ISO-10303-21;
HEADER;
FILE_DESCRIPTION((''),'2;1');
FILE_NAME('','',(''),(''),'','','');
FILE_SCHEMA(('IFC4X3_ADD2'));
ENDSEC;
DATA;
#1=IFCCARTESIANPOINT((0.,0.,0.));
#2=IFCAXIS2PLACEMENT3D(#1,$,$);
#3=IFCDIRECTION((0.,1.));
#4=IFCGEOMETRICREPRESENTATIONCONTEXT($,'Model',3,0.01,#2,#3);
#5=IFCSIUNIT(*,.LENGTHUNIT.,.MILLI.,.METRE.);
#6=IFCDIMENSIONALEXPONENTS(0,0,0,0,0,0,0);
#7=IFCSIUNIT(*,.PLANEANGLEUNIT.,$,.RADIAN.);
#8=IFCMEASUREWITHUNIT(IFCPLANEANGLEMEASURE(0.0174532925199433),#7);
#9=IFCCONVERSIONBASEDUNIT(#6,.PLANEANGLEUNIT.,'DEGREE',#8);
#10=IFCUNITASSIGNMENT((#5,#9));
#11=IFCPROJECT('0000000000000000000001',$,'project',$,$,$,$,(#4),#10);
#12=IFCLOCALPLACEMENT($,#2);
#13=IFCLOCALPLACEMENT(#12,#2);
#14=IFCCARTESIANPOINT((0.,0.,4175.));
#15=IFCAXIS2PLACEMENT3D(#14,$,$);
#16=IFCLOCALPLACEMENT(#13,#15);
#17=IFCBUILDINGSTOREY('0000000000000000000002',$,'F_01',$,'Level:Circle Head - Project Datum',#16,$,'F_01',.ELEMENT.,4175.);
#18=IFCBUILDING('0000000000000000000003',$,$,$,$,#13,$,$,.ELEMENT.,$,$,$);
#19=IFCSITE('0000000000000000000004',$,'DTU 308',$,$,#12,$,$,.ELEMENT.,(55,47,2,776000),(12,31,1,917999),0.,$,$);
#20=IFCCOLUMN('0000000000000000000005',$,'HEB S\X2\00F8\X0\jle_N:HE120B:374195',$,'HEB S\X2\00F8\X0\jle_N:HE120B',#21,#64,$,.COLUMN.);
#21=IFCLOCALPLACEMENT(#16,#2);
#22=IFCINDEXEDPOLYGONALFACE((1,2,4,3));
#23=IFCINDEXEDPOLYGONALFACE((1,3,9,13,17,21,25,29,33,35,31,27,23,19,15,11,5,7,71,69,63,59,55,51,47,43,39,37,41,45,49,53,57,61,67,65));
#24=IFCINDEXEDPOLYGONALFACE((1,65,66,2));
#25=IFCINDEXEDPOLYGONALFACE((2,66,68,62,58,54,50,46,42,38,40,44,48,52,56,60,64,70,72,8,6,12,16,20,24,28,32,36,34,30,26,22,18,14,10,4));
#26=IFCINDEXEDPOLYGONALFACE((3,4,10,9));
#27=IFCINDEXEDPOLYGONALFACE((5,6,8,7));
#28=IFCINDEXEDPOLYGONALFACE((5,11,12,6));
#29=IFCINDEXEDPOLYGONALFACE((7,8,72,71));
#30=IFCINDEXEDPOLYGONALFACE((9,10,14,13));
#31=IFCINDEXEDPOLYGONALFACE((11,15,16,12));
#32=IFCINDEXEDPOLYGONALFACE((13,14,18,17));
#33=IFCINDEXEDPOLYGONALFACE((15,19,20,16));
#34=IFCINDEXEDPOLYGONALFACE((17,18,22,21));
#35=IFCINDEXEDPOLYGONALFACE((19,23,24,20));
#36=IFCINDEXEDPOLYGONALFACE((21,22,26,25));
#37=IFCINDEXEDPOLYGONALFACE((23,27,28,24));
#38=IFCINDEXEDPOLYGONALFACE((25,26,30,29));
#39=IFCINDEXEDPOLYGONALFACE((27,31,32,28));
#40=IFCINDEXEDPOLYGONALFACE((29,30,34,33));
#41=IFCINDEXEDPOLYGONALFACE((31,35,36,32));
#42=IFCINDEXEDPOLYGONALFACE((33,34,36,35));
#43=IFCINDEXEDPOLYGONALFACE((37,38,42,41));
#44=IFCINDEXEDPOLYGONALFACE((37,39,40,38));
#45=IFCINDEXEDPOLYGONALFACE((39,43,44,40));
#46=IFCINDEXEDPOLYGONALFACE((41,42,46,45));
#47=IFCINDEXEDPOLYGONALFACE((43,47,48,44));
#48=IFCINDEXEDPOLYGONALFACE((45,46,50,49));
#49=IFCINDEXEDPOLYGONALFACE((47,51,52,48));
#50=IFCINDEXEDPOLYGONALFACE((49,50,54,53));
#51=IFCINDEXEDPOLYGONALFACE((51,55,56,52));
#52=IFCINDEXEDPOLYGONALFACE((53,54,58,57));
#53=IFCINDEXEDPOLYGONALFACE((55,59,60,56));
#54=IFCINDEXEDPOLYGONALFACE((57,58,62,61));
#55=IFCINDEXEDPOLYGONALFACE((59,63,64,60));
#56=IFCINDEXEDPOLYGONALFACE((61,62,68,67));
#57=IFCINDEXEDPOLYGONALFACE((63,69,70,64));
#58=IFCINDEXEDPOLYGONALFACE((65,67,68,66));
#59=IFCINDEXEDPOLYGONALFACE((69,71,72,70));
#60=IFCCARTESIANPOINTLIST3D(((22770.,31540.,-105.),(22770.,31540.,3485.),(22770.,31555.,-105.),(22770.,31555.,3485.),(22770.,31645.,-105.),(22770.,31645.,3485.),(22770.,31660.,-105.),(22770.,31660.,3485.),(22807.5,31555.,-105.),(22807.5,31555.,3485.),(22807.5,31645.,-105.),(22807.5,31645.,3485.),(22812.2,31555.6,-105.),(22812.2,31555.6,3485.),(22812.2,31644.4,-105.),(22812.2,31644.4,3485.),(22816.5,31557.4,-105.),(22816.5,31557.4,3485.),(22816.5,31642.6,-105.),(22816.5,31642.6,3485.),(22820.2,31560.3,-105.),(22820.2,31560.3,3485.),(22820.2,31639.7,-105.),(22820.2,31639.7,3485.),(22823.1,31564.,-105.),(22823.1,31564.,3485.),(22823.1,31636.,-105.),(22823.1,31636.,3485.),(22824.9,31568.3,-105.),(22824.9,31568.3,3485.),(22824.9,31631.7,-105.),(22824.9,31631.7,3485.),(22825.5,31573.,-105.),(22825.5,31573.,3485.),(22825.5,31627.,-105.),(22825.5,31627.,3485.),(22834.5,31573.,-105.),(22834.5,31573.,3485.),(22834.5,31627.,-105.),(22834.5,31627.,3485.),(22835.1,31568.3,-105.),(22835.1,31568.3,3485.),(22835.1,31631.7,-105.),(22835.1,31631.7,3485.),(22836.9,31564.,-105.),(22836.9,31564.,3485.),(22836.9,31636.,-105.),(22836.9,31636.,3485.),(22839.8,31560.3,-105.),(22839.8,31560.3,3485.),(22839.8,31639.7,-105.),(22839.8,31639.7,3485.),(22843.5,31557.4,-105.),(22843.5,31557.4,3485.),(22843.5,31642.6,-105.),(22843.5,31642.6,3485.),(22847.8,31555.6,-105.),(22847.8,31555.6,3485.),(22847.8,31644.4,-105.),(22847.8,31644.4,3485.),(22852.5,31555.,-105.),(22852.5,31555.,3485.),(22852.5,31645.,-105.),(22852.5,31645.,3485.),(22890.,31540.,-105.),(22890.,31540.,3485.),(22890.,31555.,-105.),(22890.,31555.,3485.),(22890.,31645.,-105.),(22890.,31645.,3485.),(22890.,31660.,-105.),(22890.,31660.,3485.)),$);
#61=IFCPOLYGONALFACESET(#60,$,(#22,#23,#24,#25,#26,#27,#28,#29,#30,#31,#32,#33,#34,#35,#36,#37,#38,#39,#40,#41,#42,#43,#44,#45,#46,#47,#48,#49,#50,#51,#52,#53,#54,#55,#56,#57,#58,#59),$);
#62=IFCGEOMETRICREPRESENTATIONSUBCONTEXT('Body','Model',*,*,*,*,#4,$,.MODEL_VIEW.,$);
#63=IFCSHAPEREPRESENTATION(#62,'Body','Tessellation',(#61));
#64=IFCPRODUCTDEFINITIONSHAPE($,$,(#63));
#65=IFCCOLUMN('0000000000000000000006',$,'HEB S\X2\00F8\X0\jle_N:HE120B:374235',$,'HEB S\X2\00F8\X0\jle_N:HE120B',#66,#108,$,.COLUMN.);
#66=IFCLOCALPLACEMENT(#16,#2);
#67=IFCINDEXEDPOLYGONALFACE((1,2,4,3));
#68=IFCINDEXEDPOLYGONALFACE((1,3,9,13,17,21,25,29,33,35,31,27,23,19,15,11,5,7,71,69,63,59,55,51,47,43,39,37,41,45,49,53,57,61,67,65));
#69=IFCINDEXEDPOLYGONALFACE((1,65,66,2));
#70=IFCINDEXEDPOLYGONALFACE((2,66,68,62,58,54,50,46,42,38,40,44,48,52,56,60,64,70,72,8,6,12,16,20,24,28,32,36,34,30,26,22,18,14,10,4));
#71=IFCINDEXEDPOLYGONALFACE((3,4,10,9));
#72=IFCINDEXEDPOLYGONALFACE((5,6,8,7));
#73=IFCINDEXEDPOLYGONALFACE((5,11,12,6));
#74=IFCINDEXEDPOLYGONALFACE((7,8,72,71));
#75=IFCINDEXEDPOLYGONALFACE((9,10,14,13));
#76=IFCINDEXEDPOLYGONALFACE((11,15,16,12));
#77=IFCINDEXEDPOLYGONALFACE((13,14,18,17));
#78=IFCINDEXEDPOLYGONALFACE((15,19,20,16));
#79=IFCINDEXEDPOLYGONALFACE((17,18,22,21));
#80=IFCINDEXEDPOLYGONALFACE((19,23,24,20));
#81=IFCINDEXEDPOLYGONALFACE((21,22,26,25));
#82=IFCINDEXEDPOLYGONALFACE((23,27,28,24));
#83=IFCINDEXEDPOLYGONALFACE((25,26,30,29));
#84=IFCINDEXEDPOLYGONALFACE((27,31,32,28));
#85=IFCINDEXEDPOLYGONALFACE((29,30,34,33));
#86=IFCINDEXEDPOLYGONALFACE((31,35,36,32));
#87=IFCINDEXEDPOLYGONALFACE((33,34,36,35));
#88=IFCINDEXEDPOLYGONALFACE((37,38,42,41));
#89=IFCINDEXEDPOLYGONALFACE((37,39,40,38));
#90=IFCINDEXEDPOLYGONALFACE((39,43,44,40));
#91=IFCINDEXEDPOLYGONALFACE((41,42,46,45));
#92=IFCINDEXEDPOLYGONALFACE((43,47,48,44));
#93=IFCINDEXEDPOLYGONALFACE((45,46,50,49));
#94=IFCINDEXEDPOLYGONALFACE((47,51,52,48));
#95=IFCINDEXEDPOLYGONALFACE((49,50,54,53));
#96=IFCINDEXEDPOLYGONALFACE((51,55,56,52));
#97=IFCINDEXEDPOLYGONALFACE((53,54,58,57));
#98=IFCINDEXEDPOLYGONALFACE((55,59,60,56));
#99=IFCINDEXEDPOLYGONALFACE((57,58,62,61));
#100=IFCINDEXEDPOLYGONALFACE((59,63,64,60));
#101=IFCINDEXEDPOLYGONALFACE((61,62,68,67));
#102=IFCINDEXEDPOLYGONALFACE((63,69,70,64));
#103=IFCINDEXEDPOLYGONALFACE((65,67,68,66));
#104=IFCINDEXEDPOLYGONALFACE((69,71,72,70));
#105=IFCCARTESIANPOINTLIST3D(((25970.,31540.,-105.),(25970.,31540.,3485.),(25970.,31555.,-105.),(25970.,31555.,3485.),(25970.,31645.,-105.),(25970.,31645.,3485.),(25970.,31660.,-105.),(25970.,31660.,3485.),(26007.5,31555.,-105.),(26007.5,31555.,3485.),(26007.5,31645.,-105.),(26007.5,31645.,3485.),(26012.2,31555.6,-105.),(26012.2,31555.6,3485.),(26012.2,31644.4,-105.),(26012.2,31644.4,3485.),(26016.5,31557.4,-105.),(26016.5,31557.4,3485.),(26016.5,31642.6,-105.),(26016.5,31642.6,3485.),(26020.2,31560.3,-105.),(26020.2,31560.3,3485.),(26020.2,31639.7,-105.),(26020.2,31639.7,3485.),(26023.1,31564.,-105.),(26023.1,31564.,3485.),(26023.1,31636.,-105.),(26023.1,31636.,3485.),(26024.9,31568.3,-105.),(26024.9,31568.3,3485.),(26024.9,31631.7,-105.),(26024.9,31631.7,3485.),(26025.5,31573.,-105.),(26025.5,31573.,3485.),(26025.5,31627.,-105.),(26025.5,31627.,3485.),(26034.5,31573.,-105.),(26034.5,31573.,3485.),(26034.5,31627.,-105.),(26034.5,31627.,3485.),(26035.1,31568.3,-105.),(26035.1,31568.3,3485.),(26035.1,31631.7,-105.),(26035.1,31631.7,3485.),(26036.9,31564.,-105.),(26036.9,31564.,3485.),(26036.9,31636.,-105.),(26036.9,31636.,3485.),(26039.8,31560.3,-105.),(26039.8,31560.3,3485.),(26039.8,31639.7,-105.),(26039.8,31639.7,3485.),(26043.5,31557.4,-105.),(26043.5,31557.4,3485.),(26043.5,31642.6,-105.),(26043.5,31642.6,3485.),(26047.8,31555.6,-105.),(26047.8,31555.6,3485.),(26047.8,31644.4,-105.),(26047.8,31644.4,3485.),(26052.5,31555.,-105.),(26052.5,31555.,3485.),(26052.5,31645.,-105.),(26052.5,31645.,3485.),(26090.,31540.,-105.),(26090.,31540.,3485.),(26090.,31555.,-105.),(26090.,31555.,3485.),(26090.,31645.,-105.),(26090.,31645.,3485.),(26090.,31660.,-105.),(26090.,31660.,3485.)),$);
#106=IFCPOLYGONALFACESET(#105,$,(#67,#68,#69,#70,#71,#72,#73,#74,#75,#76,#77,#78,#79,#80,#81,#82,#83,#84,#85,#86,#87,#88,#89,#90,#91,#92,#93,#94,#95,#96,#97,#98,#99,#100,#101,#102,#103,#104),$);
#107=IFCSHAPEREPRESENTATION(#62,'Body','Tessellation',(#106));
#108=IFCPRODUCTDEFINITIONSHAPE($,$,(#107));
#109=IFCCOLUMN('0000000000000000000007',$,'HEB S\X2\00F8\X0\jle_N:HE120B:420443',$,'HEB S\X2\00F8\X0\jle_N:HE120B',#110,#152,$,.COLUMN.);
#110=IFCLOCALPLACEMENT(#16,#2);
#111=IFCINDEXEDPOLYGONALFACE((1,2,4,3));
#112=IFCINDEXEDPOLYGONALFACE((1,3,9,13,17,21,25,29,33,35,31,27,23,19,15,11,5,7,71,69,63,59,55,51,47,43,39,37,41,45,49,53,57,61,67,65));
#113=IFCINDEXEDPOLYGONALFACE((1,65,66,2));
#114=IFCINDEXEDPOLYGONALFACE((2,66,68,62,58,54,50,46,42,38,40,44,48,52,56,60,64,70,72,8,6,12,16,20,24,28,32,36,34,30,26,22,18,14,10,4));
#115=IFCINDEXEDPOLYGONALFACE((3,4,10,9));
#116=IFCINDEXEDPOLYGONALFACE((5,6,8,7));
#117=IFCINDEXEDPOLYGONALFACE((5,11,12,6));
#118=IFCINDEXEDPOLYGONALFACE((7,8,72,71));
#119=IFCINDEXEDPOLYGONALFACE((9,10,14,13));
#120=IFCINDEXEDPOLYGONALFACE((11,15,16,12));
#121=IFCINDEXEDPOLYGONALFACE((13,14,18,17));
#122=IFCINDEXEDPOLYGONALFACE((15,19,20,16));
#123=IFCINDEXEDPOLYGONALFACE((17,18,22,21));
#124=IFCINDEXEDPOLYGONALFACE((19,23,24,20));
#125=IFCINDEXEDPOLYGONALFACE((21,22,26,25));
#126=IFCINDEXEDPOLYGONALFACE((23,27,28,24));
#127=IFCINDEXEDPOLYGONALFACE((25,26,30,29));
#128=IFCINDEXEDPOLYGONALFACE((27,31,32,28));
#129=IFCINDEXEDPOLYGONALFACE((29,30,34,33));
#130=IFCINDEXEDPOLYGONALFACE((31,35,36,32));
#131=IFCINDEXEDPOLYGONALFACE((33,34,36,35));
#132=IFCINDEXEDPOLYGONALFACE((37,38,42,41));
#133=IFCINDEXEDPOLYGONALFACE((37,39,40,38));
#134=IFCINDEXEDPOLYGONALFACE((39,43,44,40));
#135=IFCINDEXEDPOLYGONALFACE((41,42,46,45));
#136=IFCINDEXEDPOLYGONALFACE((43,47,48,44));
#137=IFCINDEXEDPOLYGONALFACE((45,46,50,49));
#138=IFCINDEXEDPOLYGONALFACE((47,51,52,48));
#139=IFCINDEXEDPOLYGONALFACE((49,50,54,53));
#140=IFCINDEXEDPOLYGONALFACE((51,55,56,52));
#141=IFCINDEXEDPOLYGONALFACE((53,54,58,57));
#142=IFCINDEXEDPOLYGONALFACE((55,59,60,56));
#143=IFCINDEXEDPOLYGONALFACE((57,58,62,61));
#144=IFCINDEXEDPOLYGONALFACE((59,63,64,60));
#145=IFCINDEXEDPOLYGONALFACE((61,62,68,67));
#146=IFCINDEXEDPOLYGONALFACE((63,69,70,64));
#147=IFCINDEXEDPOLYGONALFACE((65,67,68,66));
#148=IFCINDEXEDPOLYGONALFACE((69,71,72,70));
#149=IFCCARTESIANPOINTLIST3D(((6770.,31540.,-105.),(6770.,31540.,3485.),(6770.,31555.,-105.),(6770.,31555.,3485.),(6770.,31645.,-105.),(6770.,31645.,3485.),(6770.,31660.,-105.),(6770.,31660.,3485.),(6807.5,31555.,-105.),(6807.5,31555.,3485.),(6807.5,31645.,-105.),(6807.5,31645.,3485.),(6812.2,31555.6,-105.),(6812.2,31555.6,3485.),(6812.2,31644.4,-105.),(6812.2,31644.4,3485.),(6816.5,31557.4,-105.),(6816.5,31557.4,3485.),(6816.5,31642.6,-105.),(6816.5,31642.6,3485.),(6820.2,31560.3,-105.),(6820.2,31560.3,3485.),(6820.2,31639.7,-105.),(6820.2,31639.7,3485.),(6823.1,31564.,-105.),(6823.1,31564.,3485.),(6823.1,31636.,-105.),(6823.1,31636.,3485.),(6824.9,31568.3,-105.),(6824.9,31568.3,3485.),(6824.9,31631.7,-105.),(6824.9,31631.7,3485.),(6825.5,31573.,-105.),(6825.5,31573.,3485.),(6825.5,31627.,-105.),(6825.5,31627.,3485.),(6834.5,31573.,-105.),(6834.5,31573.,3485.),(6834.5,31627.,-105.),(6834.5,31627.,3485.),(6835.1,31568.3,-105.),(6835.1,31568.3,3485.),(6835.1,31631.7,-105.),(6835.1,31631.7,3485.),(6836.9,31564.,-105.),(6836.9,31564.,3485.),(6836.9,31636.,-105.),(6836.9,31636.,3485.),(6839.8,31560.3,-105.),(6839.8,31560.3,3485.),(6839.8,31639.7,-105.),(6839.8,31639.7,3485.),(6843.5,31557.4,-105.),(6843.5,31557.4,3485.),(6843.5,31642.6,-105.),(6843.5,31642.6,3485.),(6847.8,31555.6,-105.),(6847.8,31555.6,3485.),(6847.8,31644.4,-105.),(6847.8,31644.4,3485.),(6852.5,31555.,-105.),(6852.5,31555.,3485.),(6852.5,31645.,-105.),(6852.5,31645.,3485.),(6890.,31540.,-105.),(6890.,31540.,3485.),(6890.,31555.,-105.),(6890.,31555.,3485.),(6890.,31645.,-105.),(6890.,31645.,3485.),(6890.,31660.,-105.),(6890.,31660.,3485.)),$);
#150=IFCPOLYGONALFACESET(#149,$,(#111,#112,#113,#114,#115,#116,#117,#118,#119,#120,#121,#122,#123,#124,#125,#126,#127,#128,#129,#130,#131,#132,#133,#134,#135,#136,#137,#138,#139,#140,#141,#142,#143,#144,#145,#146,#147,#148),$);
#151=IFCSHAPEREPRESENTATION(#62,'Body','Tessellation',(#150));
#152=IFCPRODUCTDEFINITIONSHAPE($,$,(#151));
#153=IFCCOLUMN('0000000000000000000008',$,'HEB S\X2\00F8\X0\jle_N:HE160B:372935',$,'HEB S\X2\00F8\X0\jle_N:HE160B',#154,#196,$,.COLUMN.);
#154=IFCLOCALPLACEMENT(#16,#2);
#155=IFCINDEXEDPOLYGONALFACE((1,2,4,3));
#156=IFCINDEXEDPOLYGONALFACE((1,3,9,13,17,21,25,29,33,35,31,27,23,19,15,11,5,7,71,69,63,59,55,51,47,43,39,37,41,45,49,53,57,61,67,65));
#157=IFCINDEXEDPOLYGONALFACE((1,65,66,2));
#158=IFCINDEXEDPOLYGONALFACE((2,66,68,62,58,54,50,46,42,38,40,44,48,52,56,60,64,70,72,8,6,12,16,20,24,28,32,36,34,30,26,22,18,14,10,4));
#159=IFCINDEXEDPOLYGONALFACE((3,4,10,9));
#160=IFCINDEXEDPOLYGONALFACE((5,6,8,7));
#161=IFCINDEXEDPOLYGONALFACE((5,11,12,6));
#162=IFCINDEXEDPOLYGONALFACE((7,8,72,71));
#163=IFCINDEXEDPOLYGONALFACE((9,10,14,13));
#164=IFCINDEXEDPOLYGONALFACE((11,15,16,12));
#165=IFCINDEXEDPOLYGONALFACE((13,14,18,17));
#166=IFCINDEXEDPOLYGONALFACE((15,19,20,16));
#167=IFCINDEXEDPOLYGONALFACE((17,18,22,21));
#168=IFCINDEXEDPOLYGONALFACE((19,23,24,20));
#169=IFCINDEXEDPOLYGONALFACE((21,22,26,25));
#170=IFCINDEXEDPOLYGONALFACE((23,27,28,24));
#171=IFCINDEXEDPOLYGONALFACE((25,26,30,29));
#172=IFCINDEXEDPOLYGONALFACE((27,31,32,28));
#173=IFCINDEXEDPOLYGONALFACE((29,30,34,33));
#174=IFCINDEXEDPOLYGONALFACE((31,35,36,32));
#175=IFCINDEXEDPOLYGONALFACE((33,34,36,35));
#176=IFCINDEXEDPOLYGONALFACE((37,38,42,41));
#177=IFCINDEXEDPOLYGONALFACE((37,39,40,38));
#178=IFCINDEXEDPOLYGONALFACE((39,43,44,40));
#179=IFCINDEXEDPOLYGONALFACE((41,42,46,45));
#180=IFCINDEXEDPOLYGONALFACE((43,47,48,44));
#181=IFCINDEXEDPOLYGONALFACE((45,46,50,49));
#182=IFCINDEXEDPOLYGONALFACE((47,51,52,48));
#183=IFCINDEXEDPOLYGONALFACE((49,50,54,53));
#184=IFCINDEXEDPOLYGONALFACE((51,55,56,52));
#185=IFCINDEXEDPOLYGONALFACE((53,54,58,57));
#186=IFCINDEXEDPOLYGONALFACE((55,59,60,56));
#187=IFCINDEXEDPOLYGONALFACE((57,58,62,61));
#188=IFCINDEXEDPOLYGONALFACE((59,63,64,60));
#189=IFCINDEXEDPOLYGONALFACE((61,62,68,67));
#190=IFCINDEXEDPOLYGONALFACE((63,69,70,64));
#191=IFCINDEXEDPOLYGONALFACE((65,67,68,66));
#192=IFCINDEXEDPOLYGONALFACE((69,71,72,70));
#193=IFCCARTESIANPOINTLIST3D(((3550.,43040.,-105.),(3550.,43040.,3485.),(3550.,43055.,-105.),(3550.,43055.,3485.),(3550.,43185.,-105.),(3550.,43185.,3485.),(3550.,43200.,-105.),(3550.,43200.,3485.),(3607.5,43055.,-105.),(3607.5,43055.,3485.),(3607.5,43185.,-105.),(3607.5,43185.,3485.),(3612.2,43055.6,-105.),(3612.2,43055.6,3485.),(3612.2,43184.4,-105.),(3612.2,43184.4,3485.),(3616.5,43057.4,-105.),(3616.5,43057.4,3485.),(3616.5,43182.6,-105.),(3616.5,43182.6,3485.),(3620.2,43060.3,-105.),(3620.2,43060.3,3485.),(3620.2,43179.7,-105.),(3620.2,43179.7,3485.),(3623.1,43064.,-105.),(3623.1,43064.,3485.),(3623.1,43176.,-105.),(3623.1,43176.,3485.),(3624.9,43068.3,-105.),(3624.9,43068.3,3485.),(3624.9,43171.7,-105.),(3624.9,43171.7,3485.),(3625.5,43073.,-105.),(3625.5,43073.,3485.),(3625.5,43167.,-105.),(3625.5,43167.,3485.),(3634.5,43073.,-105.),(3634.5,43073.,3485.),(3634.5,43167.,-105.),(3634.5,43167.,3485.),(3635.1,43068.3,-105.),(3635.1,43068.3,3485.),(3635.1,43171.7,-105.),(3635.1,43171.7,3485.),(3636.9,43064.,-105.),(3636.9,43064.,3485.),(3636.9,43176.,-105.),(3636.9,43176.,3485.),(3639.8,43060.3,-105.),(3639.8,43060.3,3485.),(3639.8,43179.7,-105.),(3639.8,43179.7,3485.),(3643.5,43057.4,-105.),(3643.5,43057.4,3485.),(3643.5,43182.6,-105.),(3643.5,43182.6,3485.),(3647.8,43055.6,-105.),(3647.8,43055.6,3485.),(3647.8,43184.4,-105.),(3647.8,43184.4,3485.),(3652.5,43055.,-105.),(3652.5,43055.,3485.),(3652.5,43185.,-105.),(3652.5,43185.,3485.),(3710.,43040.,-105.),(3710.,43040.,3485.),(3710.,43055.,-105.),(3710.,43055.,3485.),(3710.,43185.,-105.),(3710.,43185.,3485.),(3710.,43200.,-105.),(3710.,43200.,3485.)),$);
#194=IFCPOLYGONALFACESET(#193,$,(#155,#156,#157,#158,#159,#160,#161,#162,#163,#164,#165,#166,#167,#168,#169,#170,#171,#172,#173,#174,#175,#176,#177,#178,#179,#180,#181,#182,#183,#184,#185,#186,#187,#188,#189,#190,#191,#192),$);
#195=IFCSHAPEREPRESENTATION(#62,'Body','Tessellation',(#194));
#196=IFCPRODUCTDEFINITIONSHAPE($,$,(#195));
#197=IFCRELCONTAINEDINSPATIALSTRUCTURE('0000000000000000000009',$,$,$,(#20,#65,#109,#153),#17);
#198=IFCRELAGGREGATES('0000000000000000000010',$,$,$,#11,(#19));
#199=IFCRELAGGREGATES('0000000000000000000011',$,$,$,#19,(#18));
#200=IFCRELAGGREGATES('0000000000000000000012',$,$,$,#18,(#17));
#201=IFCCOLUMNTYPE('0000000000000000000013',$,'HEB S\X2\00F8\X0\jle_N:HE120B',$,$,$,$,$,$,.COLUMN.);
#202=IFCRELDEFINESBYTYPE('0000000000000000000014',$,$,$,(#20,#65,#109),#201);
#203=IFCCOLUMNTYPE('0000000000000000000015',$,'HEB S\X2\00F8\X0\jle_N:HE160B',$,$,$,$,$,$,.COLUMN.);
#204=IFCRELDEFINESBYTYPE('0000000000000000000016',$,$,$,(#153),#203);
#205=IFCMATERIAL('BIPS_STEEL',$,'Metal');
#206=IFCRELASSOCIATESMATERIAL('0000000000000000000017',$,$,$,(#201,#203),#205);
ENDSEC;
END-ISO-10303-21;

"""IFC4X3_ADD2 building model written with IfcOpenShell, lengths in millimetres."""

from ifc_helpers import new_model, entity, si_unit, converted_unit, direction, frame, frame_2d, origin, place, context, subcontext, project, spatial, i_section, extrude, source, transform, mapped, material, material_profile, profile_set, type_object, type_shapes, element, save


model = new_model("IFC4X3_ADD2")

# Units and contexts
model_context = context("Model", 3, precision=0.01, world=origin(), true_north=direction((0.0, 1.0)))
body_context = subcontext(model_context, "Body", "Model", "MODEL_VIEW")
ifc_project = project(units=[si_unit("LENGTHUNIT", "METRE", prefix="MILLI"), converted_unit("PLANEANGLEUNIT", "DEGREE", entity("IfcPlaneAngleMeasure", 0.0174532925199433), si_unit("PLANEANGLEUNIT", "RADIAN"), dimensions=[0, 0, 0, 0, 0, 0, 0])], contexts=[model_context])

# Site, building, storey
site_placement = place(None, origin())
site = spatial("IfcSite", under=ifc_project, at=site_placement, Name="DTU 308", CompositionType="ELEMENT", RefLatitude=(55, 47, 2, 776000), RefLongitude=(12, 31, 1, 917999), RefElevation=0.0)
building_placement = place(site_placement, origin())
building = spatial("IfcBuilding", under=site, at=building_placement, CompositionType="ELEMENT")
storey_placement = place(building_placement, frame((0.0, 0.0, 4175.0)))
storey = spatial("IfcBuildingStorey", under=building, at=storey_placement, Name="F_01", ObjectType="Level:Circle Head - Project Datum", LongName="F_01", CompositionType="ELEMENT", Elevation=4175.0)

# Columns
ifc_material_1 = material(Name="BIPS_STEEL", Category="Metal")
ifc_material_profile_1 = material_profile(ifc_material_1, i_section(OverallWidth=120.0, OverallDepth=120.0, WebThickness=9.0, FlangeThickness=15.0, FilletRadius=18.0, at=frame_2d((0.0, 0.0), x_axis=(1.0, 0.0))), Name="HE120B")
ifc_profile_set_1 = profile_set([ifc_material_profile_1], Name="HE120B")
column_type_1 = type_object("IfcColumnType", Name="HEB Søjle_N:HE120B", PredefinedType="COLUMN", material=ifc_profile_set_1)
shared_shape_1 = source(origin(), body_context, "Body", "SweptSolid", [
    extrude(i_section(OverallWidth=120.0, OverallDepth=120.0, WebThickness=9.0, FlangeThickness=15.0, FilletRadius=18.0, at=frame_2d((0.0, 0.0), x_axis=(1.0, 0.0))), frame((0.0, 0.0, 4070.0), z_axis=(0.0, 0.0, 1.0), x_axis=(-1.0, 0.0, 0.0)), (0.0, 0.0, 1.0), 3590.0),
])
type_shapes(column_type_1, [shared_shape_1])
for number, where, name in (
    (1, (22830.0, 31600.0, -4175.0), "HEB Søjle_N:HE120B:374195"),
    (2, (26030.0, 31600.0, -4175.0), "HEB Søjle_N:HE120B:374235"),
    (3, (6830.0, 31600.0, -4175.0), "HEB Søjle_N:HE120B:420443"),
):
    element("IfcColumn", number, at=place(storey_placement, frame(where)), inside=storey, type_object=column_type_1, Name=name, ObjectType="HEB Søjle_N:HE120B", PredefinedType="COLUMN", context=body_context, shape_type="MappedRepresentation", body=[
        mapped(shared_shape_1, transform((0.0, 0.0, 0.0), scale=1.0)),
    ])
ifc_material_profile_2 = material_profile(ifc_material_1, i_section(OverallWidth=160.0, OverallDepth=160.0, WebThickness=9.0, FlangeThickness=15.0, FilletRadius=18.0, at=frame_2d((0.0, 0.0), x_axis=(1.0, 0.0))), Name="HE160B")
ifc_profile_set_2 = profile_set([ifc_material_profile_2], Name="HE160B")
column_type_2 = type_object("IfcColumnType", Name="HEB Søjle_N:HE160B", PredefinedType="COLUMN", material=ifc_profile_set_2)
shared_shape_2 = source(origin(), body_context, "Body", "SweptSolid", [
    extrude(i_section(OverallWidth=160.0, OverallDepth=160.0, WebThickness=9.0, FlangeThickness=15.0, FilletRadius=18.0, at=frame_2d((0.0, 0.0), x_axis=(1.0, 0.0))), frame((0.0, 0.0, 4070.0), z_axis=(0.0, 0.0, 1.0), x_axis=(-1.0, 0.0, 0.0)), (0.0, 0.0, 1.0), 3590.0),
])
for number, where, name in (
    (4, (3630.0, 43120.0, -4175.0), "HEB Søjle_N:HE160B:372935"),
):
    element("IfcColumn", number, at=place(storey_placement, frame(where)), inside=storey, type_object=column_type_2, Name=name, ObjectType="HEB Søjle_N:HE160B", PredefinedType="COLUMN", context=body_context, shape_type="MappedRepresentation", body=[
        mapped(shared_shape_2, transform((0.0, 0.0, 0.0), scale=1.0)),
    ])

save(model, "model.ifc")
